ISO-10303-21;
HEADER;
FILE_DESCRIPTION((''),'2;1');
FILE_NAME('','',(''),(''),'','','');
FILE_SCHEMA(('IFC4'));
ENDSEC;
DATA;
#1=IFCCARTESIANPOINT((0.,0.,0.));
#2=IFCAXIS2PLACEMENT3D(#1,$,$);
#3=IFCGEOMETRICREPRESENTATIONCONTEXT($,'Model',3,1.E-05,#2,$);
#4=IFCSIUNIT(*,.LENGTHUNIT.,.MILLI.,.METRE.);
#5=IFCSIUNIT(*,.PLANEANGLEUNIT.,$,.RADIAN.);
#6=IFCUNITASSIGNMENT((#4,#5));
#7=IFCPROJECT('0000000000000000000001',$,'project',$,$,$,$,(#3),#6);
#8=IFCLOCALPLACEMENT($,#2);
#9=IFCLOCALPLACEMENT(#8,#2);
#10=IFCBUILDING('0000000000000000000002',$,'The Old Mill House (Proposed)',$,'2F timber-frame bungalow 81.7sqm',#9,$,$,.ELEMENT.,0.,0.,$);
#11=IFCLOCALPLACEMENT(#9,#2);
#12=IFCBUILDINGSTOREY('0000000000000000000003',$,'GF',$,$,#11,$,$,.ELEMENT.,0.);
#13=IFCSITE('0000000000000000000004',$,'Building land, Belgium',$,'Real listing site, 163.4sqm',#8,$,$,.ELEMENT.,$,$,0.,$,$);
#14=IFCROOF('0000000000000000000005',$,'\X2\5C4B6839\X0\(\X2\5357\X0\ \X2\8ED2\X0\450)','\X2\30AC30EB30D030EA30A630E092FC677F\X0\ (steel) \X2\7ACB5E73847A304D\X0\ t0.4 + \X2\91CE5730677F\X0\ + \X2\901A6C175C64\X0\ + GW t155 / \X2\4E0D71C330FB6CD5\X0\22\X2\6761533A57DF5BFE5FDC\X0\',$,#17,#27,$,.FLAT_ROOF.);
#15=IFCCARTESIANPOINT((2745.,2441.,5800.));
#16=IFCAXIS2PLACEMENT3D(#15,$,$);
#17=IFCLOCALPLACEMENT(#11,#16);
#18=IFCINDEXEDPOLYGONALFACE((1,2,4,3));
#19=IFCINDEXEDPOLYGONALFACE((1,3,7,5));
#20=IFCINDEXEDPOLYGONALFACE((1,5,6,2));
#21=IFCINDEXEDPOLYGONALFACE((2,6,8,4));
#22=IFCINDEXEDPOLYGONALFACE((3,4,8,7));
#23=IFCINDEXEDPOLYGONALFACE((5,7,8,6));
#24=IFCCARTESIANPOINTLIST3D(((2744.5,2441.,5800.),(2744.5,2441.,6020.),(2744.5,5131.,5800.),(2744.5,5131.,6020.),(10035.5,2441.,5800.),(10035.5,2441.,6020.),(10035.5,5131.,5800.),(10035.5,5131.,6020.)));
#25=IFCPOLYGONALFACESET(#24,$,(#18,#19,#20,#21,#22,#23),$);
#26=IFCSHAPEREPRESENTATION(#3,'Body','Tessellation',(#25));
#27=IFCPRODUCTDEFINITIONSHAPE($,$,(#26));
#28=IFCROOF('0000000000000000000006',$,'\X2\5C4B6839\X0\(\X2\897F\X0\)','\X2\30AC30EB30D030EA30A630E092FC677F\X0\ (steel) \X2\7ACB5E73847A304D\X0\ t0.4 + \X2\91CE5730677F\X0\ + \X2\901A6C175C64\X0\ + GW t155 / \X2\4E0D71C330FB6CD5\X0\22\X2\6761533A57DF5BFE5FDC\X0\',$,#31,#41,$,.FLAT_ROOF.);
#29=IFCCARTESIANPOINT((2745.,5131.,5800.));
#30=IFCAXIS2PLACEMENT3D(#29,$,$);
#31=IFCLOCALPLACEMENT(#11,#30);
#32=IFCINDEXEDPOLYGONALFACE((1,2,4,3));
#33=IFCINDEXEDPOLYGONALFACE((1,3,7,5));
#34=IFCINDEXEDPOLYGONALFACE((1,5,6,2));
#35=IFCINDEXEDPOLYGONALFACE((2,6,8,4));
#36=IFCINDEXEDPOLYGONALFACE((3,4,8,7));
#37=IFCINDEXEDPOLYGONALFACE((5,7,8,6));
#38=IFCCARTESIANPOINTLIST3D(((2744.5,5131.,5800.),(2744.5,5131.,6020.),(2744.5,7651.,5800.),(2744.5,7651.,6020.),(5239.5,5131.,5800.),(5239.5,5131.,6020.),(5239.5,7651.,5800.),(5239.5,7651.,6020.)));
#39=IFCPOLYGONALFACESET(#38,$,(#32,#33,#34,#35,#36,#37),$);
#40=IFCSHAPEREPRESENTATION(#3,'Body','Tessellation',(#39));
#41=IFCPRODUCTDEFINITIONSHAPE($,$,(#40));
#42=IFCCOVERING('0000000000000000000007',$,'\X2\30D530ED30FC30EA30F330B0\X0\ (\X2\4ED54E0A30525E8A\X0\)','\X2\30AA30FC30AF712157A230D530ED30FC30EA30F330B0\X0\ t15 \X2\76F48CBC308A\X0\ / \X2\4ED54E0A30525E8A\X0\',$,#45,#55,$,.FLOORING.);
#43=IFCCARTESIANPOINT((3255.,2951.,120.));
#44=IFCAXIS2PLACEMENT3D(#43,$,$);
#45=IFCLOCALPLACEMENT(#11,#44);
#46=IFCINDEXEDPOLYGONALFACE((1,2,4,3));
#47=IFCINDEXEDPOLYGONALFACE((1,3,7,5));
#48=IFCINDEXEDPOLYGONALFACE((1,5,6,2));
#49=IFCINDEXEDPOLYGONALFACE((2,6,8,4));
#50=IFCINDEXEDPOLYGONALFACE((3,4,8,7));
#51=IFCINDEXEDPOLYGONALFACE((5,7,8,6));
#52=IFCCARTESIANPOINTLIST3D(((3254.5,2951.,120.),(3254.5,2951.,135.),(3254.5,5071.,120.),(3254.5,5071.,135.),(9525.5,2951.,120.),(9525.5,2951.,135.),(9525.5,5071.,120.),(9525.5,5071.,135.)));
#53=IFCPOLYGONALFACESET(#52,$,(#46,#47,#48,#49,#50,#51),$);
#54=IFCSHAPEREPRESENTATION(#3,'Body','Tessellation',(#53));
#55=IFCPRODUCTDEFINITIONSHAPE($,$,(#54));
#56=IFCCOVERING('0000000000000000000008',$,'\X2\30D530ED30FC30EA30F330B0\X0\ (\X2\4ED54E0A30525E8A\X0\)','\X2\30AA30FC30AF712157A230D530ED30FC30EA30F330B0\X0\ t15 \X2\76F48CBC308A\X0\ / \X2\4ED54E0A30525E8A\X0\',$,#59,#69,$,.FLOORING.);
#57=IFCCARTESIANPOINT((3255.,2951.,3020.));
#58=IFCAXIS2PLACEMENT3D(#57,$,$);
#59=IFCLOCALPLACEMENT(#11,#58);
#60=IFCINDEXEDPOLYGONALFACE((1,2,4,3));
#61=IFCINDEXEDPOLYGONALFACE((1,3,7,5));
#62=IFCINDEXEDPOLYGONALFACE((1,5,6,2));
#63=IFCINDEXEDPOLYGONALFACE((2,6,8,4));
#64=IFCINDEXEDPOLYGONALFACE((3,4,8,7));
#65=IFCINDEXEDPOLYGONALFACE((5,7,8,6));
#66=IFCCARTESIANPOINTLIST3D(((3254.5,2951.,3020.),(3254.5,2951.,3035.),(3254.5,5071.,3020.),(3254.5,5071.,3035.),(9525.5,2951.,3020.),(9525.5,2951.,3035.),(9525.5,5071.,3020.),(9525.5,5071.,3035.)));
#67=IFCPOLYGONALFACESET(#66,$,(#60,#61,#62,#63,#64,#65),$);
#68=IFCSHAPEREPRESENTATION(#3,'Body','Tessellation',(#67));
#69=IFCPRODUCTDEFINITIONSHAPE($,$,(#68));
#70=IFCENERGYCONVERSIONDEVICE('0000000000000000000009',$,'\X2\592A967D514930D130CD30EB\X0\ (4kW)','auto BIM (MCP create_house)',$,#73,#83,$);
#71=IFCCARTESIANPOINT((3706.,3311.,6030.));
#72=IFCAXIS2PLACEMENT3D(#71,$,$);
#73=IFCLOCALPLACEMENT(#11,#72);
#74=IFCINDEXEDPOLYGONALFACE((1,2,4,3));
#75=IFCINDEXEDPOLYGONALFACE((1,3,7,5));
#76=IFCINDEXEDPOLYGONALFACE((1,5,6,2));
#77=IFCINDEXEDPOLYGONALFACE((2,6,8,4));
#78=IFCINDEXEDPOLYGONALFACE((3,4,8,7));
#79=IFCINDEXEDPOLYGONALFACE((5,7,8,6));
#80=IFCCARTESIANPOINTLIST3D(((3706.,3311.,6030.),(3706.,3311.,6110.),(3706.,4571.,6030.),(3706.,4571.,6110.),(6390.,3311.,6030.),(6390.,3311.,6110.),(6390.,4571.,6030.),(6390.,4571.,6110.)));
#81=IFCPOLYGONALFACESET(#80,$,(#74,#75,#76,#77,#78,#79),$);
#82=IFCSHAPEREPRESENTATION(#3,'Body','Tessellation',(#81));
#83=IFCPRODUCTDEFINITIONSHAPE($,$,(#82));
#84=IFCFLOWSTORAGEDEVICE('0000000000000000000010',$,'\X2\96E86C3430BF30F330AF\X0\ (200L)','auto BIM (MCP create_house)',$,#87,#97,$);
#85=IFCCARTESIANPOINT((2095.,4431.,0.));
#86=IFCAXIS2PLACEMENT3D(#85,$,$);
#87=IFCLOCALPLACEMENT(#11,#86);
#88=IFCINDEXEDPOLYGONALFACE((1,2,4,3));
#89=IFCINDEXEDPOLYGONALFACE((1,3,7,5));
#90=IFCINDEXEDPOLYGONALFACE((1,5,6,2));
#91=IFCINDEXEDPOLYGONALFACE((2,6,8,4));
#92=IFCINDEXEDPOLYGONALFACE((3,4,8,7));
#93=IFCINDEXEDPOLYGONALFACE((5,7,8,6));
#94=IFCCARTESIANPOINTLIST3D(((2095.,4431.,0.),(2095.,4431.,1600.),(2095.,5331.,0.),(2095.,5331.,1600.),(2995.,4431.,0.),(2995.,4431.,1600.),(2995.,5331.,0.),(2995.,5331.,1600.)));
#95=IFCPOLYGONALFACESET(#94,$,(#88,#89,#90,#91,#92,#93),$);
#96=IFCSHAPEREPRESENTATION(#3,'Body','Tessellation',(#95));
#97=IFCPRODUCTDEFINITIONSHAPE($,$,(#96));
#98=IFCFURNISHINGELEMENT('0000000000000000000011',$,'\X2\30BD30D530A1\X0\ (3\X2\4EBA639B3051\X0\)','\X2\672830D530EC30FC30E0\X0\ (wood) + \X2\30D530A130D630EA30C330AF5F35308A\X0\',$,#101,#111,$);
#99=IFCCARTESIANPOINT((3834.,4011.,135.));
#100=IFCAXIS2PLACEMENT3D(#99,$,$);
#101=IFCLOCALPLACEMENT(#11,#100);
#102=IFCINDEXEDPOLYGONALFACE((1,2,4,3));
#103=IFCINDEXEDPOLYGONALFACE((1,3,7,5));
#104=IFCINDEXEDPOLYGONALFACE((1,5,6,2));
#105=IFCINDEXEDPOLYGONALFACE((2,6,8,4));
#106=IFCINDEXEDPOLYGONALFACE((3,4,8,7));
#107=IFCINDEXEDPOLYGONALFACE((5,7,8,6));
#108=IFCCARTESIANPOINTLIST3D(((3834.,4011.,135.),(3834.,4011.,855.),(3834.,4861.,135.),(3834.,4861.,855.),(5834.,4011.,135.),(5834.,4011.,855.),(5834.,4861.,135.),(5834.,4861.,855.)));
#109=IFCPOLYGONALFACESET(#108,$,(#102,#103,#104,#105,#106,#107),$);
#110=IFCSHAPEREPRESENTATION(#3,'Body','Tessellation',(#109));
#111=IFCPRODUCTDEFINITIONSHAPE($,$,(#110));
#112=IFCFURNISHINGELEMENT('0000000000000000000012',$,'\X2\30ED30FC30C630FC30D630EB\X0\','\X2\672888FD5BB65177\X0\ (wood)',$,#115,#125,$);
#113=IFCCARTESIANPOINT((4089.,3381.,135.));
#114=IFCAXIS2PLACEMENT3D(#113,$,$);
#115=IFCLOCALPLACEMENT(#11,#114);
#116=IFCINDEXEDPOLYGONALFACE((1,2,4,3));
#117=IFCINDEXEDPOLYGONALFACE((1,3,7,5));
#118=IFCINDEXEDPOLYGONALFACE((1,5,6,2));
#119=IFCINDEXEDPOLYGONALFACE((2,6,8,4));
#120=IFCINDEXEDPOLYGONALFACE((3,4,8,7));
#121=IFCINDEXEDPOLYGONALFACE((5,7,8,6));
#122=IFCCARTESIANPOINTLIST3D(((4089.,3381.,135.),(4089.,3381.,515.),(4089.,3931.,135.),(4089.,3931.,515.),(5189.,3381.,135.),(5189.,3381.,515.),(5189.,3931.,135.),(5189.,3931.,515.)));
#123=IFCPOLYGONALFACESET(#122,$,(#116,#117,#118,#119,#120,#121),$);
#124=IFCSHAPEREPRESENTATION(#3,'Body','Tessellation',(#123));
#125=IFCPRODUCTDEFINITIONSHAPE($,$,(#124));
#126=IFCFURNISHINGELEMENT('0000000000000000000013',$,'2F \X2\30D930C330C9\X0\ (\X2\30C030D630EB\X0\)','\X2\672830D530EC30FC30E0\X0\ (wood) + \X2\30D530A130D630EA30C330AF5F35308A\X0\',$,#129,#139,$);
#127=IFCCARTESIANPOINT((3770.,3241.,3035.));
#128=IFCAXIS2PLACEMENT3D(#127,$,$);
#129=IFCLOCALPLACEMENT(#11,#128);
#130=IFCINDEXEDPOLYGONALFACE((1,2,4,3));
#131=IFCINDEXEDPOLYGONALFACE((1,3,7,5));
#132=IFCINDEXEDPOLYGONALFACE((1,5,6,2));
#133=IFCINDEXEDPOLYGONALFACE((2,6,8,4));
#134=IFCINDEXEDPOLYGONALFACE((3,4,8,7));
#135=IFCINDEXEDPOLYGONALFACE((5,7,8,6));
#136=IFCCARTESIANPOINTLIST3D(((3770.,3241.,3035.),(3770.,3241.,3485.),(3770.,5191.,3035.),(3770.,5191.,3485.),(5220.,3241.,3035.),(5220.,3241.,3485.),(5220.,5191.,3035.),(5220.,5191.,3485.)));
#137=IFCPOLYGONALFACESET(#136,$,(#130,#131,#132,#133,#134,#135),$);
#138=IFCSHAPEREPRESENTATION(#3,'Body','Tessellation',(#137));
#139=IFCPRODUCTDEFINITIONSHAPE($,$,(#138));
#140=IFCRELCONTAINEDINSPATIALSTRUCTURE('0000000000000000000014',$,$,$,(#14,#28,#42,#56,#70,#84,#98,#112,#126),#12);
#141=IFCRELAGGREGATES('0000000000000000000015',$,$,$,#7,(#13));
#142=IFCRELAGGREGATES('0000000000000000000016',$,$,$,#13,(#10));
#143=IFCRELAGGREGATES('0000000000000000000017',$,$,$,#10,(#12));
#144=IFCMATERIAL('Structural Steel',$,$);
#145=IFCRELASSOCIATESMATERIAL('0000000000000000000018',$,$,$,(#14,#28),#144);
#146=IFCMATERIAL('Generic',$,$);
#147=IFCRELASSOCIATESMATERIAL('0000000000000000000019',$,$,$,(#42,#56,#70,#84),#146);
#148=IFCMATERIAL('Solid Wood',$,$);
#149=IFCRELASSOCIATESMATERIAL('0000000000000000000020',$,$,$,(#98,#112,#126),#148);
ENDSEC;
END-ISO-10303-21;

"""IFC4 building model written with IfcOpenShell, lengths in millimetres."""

from ifc_helpers import new_model, si_unit, frame, frame_2d, origin, place, context, project, spatial, rectangle, extrude, material, element, save


model = new_model("IFC4")

# Units and contexts
model_context = context("Model", 3, precision=1e-05, world=origin())
ifc_project = project(units=[si_unit("LENGTHUNIT", "METRE", prefix="MILLI"), si_unit("PLANEANGLEUNIT", "RADIAN")], contexts=[model_context])

# Site, building, storey
site_placement = place(None, origin())
site = spatial("IfcSite", under=ifc_project, at=site_placement, Name="Building land, Belgium", ObjectType="Real listing site, 163.4sqm", CompositionType="ELEMENT", RefElevation=0.0)
building_placement = place(site_placement, origin())
building = spatial("IfcBuilding", under=site, at=building_placement, Name="The Old Mill House (Proposed)", ObjectType="2F timber-frame bungalow 81.7sqm", CompositionType="ELEMENT", ElevationOfRefHeight=0.0, ElevationOfTerrain=0.0)
storey_placement = place(building_placement, origin())
storey = spatial("IfcBuildingStorey", under=building, at=storey_placement, Name="GF", CompositionType="ELEMENT", Elevation=0.0)

# Shared definitions
ifc_material_1 = material(Name="Solid Wood")

# Roofs
ifc_material_2 = material(Name="Structural Steel")
roof_1_placement = place(storey_placement, frame((2745.0, 2441.0, 5800.0)))
element("IfcRoof", 1, at=roof_1_placement, inside=storey, material=ifc_material_2, Name="屋根(南 軒450)", Description="ガルバリウム鋼板 (steel) 立平葺き t0.4 + 野地板 + 通気層 + GW t155 / 不燃・法22条区域対応", PredefinedType="FLAT_ROOF", context=model_context, shape_type="SweptSolid", body=[
    extrude(rectangle(XDim=7291.0, YDim=2690.0, at=frame_2d((3645.0, 1345.0))), frame((2745.0, 2441.0, 5800.0)), (0.0, 0.0, 1.0), 220.0),
])
roof_2_placement = place(storey_placement, frame((2745.0, 5131.0, 5800.0)))
element("IfcRoof", 2, at=roof_2_placement, inside=storey, material=ifc_material_2, Name="屋根(西)", Description="ガルバリウム鋼板 (steel) 立平葺き t0.4 + 野地板 + 通気層 + GW t155 / 不燃・法22条区域対応", PredefinedType="FLAT_ROOF", context=model_context, shape_type="SweptSolid", body=[
    extrude(rectangle(XDim=2495.0, YDim=2520.0, at=frame_2d((1247.0, 1260.0))), frame((2745.0, 5131.0, 5800.0)), (0.0, 0.0, 1.0), 220.0),
])

# Coverings
ifc_material_3 = material(Name="Generic")
covering_1_placement = place(storey_placement, frame((3255.0, 2951.0, 120.0)))
element("IfcCovering", 3, at=covering_1_placement, inside=storey, material=ifc_material_3, Name="フローリング (仕上げ床)", Description="オーク無垢フローリング t15 直貼り / 仕上げ床", PredefinedType="FLOORING", context=model_context, shape_type="SweptSolid", body=[
    extrude(rectangle(XDim=6271.0, YDim=2120.0, at=frame_2d((3135.0, 1060.0))), frame((3255.0, 2951.0, 120.0)), (0.0, 0.0, 1.0), 15.0),
])
covering_2_placement = place(storey_placement, frame((3255.0, 2951.0, 3020.0)))
element("IfcCovering", 4, at=covering_2_placement, inside=storey, material=ifc_material_3, Name="フローリング (仕上げ床)", Description="オーク無垢フローリング t15 直貼り / 仕上げ床", PredefinedType="FLOORING", context=model_context, shape_type="SweptSolid", body=[
    extrude(rectangle(XDim=6271.0, YDim=2120.0, at=frame_2d((3135.0, 1060.0))), frame((3255.0, 2951.0, 3020.0)), (0.0, 0.0, 1.0), 15.0),
])

# Energy conversion device
energy_conversion_device_placement = place(storey_placement, frame((3706.0, 3311.0, 6030.0)))
element("IfcEnergyConversionDevice", 5, at=energy_conversion_device_placement, inside=storey, material=ifc_material_3, Name="太陽光パネル (4kW)", Description="auto BIM (MCP create_house)", context=model_context, shape_type="SweptSolid", body=[
    extrude(rectangle(XDim=2684.0, YDim=1260.0, at=frame_2d((1342.0, 630.0))), frame((3706.0, 3311.0, 6030.0)), (0.0, 0.0, 1.0), 80.0),
])

# Flow storage device
flow_storage_device_placement = place(storey_placement, frame((2095.0, 4431.0, 0.0)))
element("IfcFlowStorageDevice", 6, at=flow_storage_device_placement, inside=storey, material=ifc_material_3, Name="雨水タンク (200L)", Description="auto BIM (MCP create_house)", context=model_context, shape_type="SweptSolid", body=[
    extrude(rectangle(XDim=900.0, YDim=900.0, at=frame_2d((450.0, 450.0))), frame((2095.0, 4431.0, 0.0)), (0.0, 0.0, 1.0), 1600.0),
])

# Furnishing elements
furnishing_1_placement = place(storey_placement, frame((3834.0, 4011.0, 135.0)))
element("IfcFurnishingElement", 7, at=furnishing_1_placement, inside=storey, material=ifc_material_1, Name="ソファ (3人掛け)", Description="木フレーム (wood) + ファブリック張り", context=model_context, shape_type="SweptSolid", body=[
    extrude(rectangle(XDim=2000.0, YDim=850.0, at=frame_2d((1000.0, 425.0))), frame((3834.0, 4011.0, 135.0)), (0.0, 0.0, 1.0), 720.0),
])
furnishing_2_placement = place(storey_placement, frame((4089.0, 3381.0, 135.0)))
element("IfcFurnishingElement", 8, at=furnishing_2_placement, inside=storey, material=ifc_material_1, Name="ローテーブル", Description="木製家具 (wood)", context=model_context, shape_type="SweptSolid", body=[
    extrude(rectangle(XDim=1100.0, YDim=550.0, at=frame_2d((550.0, 275.0))), frame((4089.0, 3381.0, 135.0)), (0.0, 0.0, 1.0), 380.0),
])
furnishing_3_placement = place(storey_placement, frame((3770.0, 3241.0, 3035.0)))
element("IfcFurnishingElement", 9, at=furnishing_3_placement, inside=storey, material=ifc_material_1, Name="2F ベッド (ダブル)", Description="木フレーム (wood) + ファブリック張り", context=model_context, shape_type="SweptSolid", body=[
    extrude(rectangle(XDim=1450.0, YDim=1950.0, at=frame_2d((725.0, 975.0))), frame((3770.0, 3241.0, 3035.0)), (0.0, 0.0, 1.0), 450.0),
])

save(model, "model.ifc")
